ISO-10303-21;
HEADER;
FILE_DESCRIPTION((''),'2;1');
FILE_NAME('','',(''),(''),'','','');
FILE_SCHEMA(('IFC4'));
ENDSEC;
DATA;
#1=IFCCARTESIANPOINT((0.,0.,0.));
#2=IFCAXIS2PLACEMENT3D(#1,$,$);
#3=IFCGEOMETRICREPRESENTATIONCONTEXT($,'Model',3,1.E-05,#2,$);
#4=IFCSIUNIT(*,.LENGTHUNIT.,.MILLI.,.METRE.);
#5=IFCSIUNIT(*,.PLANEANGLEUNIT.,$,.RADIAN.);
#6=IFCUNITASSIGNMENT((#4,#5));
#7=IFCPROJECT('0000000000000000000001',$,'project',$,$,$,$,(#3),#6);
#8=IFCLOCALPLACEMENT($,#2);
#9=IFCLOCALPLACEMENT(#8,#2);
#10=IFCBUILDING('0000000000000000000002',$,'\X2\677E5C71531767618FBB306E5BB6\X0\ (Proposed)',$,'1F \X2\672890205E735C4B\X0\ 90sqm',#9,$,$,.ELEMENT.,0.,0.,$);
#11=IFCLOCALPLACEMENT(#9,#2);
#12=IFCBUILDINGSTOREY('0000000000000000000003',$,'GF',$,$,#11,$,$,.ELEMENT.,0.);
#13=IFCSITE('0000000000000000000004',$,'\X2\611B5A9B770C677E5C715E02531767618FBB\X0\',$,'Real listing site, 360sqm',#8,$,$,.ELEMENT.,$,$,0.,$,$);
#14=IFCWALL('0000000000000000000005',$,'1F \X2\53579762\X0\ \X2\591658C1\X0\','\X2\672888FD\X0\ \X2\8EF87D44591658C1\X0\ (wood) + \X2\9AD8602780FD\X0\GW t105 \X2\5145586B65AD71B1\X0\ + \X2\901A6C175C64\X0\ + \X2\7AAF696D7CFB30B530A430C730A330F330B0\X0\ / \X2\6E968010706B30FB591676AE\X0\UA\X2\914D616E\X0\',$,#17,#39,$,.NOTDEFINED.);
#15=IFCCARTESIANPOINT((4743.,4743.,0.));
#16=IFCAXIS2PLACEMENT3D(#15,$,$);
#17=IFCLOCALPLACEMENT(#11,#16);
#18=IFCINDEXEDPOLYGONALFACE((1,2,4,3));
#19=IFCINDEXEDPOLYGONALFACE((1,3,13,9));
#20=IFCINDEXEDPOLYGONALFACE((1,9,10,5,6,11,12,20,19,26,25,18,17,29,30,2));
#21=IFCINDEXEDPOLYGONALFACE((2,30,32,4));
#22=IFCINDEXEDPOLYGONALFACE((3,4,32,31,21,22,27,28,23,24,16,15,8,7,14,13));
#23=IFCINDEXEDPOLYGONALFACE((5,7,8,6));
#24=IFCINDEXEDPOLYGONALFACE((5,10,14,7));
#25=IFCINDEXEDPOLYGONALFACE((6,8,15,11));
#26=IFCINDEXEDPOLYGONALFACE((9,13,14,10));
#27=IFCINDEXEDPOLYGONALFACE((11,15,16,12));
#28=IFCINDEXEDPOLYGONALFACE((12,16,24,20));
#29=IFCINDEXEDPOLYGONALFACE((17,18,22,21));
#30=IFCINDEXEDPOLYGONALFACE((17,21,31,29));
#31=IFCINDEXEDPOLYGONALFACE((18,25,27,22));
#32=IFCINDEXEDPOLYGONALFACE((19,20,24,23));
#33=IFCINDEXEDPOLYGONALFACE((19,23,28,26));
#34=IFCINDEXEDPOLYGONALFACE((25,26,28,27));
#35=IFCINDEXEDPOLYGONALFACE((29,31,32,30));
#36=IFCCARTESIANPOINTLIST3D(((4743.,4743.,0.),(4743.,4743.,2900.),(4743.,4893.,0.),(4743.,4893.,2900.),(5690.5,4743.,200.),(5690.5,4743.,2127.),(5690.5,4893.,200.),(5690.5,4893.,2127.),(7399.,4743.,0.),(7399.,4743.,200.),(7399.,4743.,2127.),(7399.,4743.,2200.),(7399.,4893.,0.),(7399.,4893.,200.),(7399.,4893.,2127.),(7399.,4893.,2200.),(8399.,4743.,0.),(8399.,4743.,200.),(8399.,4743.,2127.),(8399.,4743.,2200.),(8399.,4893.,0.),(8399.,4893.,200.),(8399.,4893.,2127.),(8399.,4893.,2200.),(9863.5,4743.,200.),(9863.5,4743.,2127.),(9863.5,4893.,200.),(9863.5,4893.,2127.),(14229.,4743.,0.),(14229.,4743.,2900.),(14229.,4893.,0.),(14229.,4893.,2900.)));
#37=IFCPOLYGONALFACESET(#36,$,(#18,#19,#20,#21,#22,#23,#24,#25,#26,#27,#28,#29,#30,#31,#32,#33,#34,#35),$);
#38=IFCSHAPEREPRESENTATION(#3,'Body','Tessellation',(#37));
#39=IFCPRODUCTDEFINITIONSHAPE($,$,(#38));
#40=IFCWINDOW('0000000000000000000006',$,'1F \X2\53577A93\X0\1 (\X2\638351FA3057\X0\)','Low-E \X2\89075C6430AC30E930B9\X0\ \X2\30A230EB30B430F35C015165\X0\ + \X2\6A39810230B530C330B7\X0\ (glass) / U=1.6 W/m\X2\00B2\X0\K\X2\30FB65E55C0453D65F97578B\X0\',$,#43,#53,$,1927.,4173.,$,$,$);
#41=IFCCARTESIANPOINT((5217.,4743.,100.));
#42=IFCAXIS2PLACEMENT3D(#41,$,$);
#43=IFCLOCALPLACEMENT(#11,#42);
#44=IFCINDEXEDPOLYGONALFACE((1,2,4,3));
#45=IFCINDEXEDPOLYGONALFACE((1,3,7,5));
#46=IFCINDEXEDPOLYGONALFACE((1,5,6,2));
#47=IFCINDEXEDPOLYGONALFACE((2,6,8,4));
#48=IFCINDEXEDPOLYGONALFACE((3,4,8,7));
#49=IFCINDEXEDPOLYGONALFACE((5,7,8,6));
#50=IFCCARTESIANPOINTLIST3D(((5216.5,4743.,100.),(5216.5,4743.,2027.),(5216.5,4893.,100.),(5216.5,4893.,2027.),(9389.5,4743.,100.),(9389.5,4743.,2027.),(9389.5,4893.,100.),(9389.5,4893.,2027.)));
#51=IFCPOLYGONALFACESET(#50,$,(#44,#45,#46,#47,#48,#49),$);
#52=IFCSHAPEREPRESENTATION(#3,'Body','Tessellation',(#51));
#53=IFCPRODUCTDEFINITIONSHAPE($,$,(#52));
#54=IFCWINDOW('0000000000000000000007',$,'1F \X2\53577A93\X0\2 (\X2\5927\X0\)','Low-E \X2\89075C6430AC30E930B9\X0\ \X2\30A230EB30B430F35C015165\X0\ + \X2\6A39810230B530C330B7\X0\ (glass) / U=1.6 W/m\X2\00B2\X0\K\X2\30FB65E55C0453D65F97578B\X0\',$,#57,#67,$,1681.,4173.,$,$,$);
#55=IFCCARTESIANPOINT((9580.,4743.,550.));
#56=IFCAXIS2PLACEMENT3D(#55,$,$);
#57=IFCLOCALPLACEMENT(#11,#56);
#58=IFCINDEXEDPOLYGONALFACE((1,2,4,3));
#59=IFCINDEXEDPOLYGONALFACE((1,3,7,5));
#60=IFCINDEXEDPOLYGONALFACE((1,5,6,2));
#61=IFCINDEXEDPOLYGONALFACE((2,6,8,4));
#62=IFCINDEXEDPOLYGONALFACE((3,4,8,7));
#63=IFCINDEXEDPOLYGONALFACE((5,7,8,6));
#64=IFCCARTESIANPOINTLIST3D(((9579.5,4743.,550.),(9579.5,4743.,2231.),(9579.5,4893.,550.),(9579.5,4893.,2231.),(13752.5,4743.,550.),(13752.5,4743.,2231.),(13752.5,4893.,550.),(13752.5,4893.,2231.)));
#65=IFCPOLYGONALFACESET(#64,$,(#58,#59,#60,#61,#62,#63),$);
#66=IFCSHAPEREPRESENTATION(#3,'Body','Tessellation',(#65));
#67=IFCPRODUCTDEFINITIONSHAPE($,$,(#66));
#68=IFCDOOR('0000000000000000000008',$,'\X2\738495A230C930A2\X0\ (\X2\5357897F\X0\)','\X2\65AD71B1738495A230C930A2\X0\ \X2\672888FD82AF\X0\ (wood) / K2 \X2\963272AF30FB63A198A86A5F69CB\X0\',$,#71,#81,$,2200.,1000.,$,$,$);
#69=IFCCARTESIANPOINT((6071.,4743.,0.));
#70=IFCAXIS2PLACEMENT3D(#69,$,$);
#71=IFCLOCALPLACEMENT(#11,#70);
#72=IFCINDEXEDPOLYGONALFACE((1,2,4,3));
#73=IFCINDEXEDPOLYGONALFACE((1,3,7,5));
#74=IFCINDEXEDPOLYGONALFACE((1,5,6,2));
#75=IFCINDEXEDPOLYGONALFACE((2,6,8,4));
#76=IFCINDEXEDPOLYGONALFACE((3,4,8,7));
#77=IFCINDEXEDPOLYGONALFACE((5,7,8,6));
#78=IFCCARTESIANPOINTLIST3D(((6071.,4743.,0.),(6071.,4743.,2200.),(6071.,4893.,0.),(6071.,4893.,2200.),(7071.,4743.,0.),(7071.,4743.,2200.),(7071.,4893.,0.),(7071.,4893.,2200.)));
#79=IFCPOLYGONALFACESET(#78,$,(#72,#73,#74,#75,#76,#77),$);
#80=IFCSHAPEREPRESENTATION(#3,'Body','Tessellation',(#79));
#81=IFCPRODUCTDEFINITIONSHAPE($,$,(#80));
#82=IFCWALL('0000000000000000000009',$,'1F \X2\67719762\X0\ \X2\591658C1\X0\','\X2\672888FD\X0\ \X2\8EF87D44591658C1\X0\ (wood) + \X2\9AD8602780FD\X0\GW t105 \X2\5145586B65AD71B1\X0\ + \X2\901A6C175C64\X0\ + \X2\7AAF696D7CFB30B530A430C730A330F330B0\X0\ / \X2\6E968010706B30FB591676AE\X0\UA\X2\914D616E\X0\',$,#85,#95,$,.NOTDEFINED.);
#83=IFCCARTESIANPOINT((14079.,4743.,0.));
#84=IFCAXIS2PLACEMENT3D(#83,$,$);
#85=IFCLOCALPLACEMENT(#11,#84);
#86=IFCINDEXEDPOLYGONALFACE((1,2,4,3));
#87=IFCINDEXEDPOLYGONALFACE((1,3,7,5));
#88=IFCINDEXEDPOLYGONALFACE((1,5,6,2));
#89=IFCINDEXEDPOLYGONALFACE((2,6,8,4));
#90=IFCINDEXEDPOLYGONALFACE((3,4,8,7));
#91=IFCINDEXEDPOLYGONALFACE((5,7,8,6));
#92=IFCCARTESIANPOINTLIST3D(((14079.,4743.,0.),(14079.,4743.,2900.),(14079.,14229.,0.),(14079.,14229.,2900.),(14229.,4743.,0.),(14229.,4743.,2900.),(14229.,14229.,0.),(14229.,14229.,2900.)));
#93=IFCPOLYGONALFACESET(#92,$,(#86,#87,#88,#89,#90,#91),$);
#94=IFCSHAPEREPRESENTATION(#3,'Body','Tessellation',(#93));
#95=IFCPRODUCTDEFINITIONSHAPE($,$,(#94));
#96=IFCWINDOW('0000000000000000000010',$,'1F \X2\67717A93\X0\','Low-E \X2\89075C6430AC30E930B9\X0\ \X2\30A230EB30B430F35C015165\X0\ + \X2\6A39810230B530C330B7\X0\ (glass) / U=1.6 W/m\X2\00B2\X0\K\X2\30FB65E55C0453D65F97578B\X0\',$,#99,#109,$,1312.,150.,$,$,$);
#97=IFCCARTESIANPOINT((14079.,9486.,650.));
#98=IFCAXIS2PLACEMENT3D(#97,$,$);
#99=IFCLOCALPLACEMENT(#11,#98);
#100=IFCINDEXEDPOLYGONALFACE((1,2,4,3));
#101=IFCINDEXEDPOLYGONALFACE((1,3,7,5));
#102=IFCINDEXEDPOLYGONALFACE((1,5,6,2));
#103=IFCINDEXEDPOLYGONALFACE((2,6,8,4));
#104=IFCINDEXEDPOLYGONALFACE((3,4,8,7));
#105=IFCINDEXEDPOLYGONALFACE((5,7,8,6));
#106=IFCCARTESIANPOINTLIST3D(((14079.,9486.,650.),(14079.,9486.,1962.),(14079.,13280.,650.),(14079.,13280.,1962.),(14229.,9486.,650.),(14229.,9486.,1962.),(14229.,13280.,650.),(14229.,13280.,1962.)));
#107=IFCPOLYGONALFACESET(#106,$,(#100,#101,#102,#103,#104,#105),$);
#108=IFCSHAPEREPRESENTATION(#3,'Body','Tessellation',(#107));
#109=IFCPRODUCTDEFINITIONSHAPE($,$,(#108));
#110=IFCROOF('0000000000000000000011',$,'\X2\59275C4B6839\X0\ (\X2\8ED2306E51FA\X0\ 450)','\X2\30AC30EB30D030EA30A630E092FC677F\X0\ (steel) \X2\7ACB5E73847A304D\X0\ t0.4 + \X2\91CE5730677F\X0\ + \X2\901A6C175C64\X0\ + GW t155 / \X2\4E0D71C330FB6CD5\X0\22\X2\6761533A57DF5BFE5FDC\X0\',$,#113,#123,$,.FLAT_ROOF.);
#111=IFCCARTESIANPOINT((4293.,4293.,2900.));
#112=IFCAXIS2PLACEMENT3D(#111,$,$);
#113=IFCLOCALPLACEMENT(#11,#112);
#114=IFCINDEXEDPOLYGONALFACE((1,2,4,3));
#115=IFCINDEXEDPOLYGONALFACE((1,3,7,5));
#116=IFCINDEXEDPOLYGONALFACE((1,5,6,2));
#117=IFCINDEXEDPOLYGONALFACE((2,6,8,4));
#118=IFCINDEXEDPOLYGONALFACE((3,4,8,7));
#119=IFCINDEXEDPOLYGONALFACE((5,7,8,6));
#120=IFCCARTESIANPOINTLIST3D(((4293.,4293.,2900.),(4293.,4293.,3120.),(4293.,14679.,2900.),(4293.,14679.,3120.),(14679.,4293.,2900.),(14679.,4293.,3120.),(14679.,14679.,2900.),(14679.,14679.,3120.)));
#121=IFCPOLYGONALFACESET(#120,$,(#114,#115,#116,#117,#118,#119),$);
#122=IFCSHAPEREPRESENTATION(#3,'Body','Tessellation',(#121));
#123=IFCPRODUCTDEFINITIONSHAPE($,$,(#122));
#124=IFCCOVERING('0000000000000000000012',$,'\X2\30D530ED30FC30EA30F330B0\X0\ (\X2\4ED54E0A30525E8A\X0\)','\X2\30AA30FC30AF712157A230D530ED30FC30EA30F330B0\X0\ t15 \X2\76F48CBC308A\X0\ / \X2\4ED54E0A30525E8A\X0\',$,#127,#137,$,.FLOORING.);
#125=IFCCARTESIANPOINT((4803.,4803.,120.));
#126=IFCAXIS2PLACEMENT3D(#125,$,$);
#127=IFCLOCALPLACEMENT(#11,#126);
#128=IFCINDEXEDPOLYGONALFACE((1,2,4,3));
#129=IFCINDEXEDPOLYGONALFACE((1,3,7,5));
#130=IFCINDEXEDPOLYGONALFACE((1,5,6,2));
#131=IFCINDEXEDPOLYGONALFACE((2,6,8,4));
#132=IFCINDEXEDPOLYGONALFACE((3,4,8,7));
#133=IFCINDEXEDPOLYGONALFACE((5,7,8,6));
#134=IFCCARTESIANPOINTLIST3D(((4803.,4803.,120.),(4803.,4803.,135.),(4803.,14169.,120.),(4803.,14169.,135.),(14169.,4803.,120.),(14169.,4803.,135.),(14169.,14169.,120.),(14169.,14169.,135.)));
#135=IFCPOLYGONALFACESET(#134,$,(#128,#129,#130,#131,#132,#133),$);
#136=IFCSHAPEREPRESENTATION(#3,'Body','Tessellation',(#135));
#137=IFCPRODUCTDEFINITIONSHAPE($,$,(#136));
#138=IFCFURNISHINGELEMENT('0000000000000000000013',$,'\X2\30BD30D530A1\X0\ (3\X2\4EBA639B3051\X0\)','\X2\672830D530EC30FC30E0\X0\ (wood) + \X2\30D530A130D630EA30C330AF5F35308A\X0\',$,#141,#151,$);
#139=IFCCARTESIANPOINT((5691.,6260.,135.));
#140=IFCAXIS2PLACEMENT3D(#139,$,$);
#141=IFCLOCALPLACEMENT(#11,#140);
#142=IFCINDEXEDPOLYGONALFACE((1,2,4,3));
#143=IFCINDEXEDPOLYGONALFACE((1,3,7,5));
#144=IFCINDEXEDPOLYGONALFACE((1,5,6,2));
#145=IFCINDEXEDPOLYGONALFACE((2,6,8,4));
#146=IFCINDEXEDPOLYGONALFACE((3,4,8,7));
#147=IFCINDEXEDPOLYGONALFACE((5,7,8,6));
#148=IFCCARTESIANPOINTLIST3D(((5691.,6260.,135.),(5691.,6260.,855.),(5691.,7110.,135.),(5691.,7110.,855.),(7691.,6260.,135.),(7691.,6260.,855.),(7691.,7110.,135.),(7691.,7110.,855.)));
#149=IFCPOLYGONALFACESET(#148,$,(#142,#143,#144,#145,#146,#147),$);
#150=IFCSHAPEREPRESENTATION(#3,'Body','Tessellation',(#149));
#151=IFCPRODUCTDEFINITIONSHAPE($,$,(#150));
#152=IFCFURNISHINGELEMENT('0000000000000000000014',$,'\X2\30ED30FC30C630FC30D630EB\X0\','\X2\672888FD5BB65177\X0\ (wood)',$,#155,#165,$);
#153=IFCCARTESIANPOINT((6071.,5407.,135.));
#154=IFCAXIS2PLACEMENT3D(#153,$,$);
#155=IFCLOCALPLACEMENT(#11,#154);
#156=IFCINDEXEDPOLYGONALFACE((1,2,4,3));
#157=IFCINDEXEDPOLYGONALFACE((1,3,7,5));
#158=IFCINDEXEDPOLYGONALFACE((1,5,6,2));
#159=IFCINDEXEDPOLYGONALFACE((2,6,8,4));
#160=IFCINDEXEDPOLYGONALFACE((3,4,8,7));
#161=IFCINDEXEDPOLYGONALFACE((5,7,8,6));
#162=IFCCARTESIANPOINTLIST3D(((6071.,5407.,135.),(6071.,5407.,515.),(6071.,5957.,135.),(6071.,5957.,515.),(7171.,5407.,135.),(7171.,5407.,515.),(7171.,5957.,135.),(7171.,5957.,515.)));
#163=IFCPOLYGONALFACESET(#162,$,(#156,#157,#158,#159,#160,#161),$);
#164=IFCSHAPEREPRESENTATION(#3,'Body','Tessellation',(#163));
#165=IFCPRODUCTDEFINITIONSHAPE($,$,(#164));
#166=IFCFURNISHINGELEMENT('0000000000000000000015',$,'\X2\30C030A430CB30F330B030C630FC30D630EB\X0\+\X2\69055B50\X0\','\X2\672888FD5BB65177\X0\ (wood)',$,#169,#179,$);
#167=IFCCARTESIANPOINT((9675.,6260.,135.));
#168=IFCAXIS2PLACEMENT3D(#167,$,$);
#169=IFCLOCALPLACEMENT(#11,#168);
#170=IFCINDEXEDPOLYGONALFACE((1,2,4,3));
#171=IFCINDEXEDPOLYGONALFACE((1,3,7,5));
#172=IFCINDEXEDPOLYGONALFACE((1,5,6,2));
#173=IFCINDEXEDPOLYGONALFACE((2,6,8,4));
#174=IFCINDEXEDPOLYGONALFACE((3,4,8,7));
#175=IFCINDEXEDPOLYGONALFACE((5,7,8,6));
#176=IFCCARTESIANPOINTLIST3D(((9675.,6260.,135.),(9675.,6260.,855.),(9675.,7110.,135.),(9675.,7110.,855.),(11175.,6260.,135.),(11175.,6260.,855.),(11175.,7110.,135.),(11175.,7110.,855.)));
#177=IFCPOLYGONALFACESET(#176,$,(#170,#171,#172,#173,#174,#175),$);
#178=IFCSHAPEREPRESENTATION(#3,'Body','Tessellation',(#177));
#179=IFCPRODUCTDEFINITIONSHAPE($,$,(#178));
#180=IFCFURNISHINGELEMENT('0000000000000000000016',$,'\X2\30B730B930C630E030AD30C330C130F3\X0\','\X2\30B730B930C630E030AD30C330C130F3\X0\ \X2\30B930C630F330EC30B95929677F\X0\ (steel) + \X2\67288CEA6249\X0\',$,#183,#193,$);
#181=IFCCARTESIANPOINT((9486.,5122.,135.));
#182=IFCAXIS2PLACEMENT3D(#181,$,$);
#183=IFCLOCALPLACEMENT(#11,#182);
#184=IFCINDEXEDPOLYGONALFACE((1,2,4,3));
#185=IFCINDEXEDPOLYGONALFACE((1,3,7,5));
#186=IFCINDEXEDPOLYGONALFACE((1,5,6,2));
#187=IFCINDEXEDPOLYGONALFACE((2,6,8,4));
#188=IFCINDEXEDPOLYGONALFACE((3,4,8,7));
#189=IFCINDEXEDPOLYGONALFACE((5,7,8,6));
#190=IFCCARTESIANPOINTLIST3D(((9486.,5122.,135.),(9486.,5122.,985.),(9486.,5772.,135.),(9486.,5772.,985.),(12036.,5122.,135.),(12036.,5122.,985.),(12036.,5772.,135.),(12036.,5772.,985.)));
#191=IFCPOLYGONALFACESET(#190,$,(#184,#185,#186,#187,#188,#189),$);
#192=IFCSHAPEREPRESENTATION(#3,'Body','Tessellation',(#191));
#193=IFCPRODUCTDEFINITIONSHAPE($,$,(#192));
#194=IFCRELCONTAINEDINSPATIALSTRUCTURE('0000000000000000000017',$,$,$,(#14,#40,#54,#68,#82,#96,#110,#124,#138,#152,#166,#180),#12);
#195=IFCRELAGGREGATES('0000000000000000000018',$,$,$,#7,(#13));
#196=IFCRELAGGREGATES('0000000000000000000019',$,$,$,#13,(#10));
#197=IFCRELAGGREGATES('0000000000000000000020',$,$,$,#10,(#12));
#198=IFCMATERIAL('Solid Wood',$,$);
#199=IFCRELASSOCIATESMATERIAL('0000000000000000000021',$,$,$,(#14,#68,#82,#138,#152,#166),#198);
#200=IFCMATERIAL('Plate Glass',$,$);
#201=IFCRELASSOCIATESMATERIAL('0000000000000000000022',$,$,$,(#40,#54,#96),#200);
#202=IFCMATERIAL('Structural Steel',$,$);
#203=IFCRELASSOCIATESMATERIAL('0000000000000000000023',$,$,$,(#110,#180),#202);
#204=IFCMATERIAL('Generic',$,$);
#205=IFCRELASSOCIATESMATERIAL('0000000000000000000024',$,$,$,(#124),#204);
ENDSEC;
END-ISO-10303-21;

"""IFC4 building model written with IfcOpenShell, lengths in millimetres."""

from ifc_helpers import new_model, si_unit, frame, frame_2d, origin, place, context, project, spatial, rectangle, extrude, material, element, fill, save


model = new_model("IFC4")

# Units and contexts
model_context = context("Model", 3, precision=1e-05, world=origin())
ifc_project = project(units=[si_unit("LENGTHUNIT", "METRE", prefix="MILLI"), si_unit("PLANEANGLEUNIT", "RADIAN")], contexts=[model_context])

# Site, building, storey
site_placement = place(None, origin())
site = spatial("IfcSite", under=ifc_project, at=site_placement, Name="愛媛県松山市北条辻", ObjectType="Real listing site, 360sqm", CompositionType="ELEMENT", RefElevation=0.0)
building_placement = place(site_placement, origin())
building = spatial("IfcBuilding", under=site, at=building_placement, Name="松山北条辻の家 (Proposed)", ObjectType="1F 木造平屋 90sqm", CompositionType="ELEMENT", ElevationOfRefHeight=0.0, ElevationOfTerrain=0.0)
storey_placement = place(building_placement, origin())
storey = spatial("IfcBuildingStorey", under=building, at=storey_placement, Name="GF", CompositionType="ELEMENT", Elevation=0.0)

# Shared definitions
ifc_material_1 = material(Name="Solid Wood")

# Wall, openings, windows, door
wall_1_placement = place(storey_placement, frame((4743.0, 4743.0, 0.0)))
wall_1 = element("IfcWall", 1, at=wall_1_placement, inside=storey, material=ifc_material_1, Name="1F 南面 外壁", Description="木製 軸組外壁 (wood) + 高性能GW t105 充填断熱 + 通気層 + 窯業系サイディング / 準耐火・外皮UA配慮", PredefinedType="NOTDEFINED", context=model_context, shape_type="SweptSolid", body=[
    extrude(rectangle(XDim=9486.0, YDim=150.0, at=frame_2d((4743.0, 75.0))), frame((4743.0, 4743.0, 0.0)), (0.0, 0.0, 1.0), 2900.0),
])
opening_1_placement = place(storey_placement, frame((5217.0, 4743.0, 100.0)))
opening_1 = element("IfcOpeningElement", 2, at=opening_1_placement, cuts=wall_1, PredefinedType="NOTDEFINED", context=model_context, shape_type="SweptSolid", body=[
    extrude(rectangle(XDim=4173.0, YDim=150.0, at=frame_2d((2086.0, 75.0))), frame((5217.0, 4743.0, 100.0)), (0.0, 0.0, 1.0), 1927.0),
])
opening_2_placement = place(storey_placement, frame((9580.0, 4743.0, 550.0)))
opening_2 = element("IfcOpeningElement", 3, at=opening_2_placement, cuts=wall_1, PredefinedType="NOTDEFINED", context=model_context, shape_type="SweptSolid", body=[
    extrude(rectangle(XDim=4173.0, YDim=150.0, at=frame_2d((2086.0, 75.0))), frame((9580.0, 4743.0, 550.0)), (0.0, 0.0, 1.0), 1681.0),
])
opening_3_placement = place(storey_placement, frame((6071.0, 4743.0, 0.0)))
opening_3 = element("IfcOpeningElement", 4, at=opening_3_placement, cuts=wall_1, PredefinedType="NOTDEFINED", context=model_context, shape_type="SweptSolid", body=[
    extrude(rectangle(XDim=1000.0, YDim=150.0, at=frame_2d((500.0, 75.0))), frame((6071.0, 4743.0, 0.0)), (0.0, 0.0, 1.0), 2200.0),
])
ifc_material_2 = material(Name="Plate Glass")
window_1_placement = place(storey_placement, frame((5217.0, 4743.0, 100.0)))
window_1 = element("IfcWindow", 5, at=window_1_placement, inside=storey, material=ifc_material_2, Name="1F 南窓1 (掃出し)", Description="Low-E 複層ガラス アルゴン封入 + 樹脂サッシ (glass) / U=1.6 W/m²K・日射取得型", OverallHeight=1927.0, OverallWidth=4173.0, context=model_context, shape_type="SweptSolid", body=[
    extrude(rectangle(XDim=4173.0, YDim=150.0, at=frame_2d((2086.0, 75.0))), frame((5217.0, 4743.0, 100.0)), (0.0, 0.0, 1.0), 1927.0),
])
fill(opening_1, window_1)
window_2_placement = place(storey_placement, frame((9580.0, 4743.0, 550.0)))
window_2 = element("IfcWindow", 6, at=window_2_placement, inside=storey, material=ifc_material_2, Name="1F 南窓2 (大)", Description="Low-E 複層ガラス アルゴン封入 + 樹脂サッシ (glass) / U=1.6 W/m²K・日射取得型", OverallHeight=1681.0, OverallWidth=4173.0, context=model_context, shape_type="SweptSolid", body=[
    extrude(rectangle(XDim=4173.0, YDim=150.0, at=frame_2d((2086.0, 75.0))), frame((9580.0, 4743.0, 550.0)), (0.0, 0.0, 1.0), 1681.0),
])
fill(opening_2, window_2)
door_placement = place(storey_placement, frame((6071.0, 4743.0, 0.0)))
door = element("IfcDoor", 7, at=door_placement, inside=storey, material=ifc_material_1, Name="玄関ドア (南西)", Description="断熱玄関ドア 木製芯 (wood) / K2 防犯・採風機構", OverallHeight=2200.0, OverallWidth=1000.0, context=model_context, shape_type="SweptSolid", body=[
    extrude(rectangle(XDim=1000.0, YDim=150.0, at=frame_2d((500.0, 75.0))), frame((6071.0, 4743.0, 0.0)), (0.0, 0.0, 1.0), 2200.0),
])
fill(opening_3, door)

# Wall, opening, window
wall_2_placement = place(storey_placement, frame((14079.0, 4743.0, 0.0)))
wall_2 = element("IfcWall", 8, at=wall_2_placement, inside=storey, material=ifc_material_1, Name="1F 東面 外壁", Description="木製 軸組外壁 (wood) + 高性能GW t105 充填断熱 + 通気層 + 窯業系サイディング / 準耐火・外皮UA配慮", PredefinedType="NOTDEFINED", context=model_context, shape_type="SweptSolid", body=[
    extrude(rectangle(XDim=150.0, YDim=9486.0, at=frame_2d((75.0, 4743.0))), frame((14079.0, 4743.0, 0.0)), (0.0, 0.0, 1.0), 2900.0),
])
opening_4_placement = place(storey_placement, frame((14079.0, 9486.0, 650.0)))
opening_4 = element("IfcOpeningElement", 9, at=opening_4_placement, cuts=wall_2, PredefinedType="NOTDEFINED", context=model_context, shape_type="SweptSolid", body=[
    extrude(rectangle(XDim=150.0, YDim=3794.0, at=frame_2d((75.0, 1897.0))), frame((14079.0, 9486.0, 650.0)), (0.0, 0.0, 1.0), 1312.0),
])
window_3_placement = place(storey_placement, frame((14079.0, 9486.0, 650.0)))
window_3 = element("IfcWindow", 10, at=window_3_placement, inside=storey, material=ifc_material_2, Name="1F 東窓", Description="Low-E 複層ガラス アルゴン封入 + 樹脂サッシ (glass) / U=1.6 W/m²K・日射取得型", OverallHeight=1312.0, OverallWidth=150.0, context=model_context, shape_type="SweptSolid", body=[
    extrude(rectangle(XDim=150.0, YDim=3794.0, at=frame_2d((75.0, 1897.0))), frame((14079.0, 9486.0, 650.0)), (0.0, 0.0, 1.0), 1312.0),
])
fill(opening_4, window_3)

# Roof
ifc_material_3 = material(Name="Structural Steel")
roof_placement = place(storey_placement, frame((4293.0, 4293.0, 2900.0)))
element("IfcRoof", 11, at=roof_placement, inside=storey, material=ifc_material_3, Name="大屋根 (軒の出 450)", Description="ガルバリウム鋼板 (steel) 立平葺き t0.4 + 野地板 + 通気層 + GW t155 / 不燃・法22条区域対応", PredefinedType="FLAT_ROOF", context=model_context, shape_type="SweptSolid", body=[
    extrude(rectangle(XDim=10386.0, YDim=10386.0, at=frame_2d((5193.0, 5193.0))), frame((4293.0, 4293.0, 2900.0)), (0.0, 0.0, 1.0), 220.0),
])

# Covering
ifc_material_4 = material(Name="Generic")
covering_placement = place(storey_placement, frame((4803.0, 4803.0, 120.0)))
element("IfcCovering", 12, at=covering_placement, inside=storey, material=ifc_material_4, Name="フローリング (仕上げ床)", Description="オーク無垢フローリング t15 直貼り / 仕上げ床", PredefinedType="FLOORING", context=model_context, shape_type="SweptSolid", body=[
    extrude(rectangle(XDim=9366.0, YDim=9366.0, at=frame_2d((4683.0, 4683.0))), frame((4803.0, 4803.0, 120.0)), (0.0, 0.0, 1.0), 15.0),
])

# Furnishing elements
furnishing_1_placement = place(storey_placement, frame((5691.0, 6260.0, 135.0)))
element("IfcFurnishingElement", 13, at=furnishing_1_placement, inside=storey, material=ifc_material_1, Name="ソファ (3人掛け)", Description="木フレーム (wood) + ファブリック張り", context=model_context, shape_type="SweptSolid", body=[
    extrude(rectangle(XDim=2000.0, YDim=850.0, at=frame_2d((1000.0, 425.0))), frame((5691.0, 6260.0, 135.0)), (0.0, 0.0, 1.0), 720.0),
])
furnishing_2_placement = place(storey_placement, frame((6071.0, 5407.0, 135.0)))
element("IfcFurnishingElement", 14, at=furnishing_2_placement, inside=storey, material=ifc_material_1, Name="ローテーブル", Description="木製家具 (wood)", context=model_context, shape_type="SweptSolid", body=[
    extrude(rectangle(XDim=1100.0, YDim=550.0, at=frame_2d((550.0, 275.0))), frame((6071.0, 5407.0, 135.0)), (0.0, 0.0, 1.0), 380.0),
])
furnishing_3_placement = place(storey_placement, frame((9675.0, 6260.0, 135.0)))
element("IfcFurnishingElement", 15, at=furnishing_3_placement, inside=storey, material=ifc_material_1, Name="ダイニングテーブル+椅子", Description="木製家具 (wood)", context=model_context, shape_type="SweptSolid", body=[
    extrude(rectangle(XDim=1500.0, YDim=850.0, at=frame_2d((750.0, 425.0))), frame((9675.0, 6260.0, 135.0)), (0.0, 0.0, 1.0), 720.0),
])
furnishing_4_placement = place(storey_placement, frame((9486.0, 5122.0, 135.0)))
element("IfcFurnishingElement", 16, at=furnishing_4_placement, inside=storey, material=ifc_material_3, Name="システムキッチン", Description="システムキッチン ステンレス天板 (steel) + 木質扉", context=model_context, shape_type="SweptSolid", body=[
    extrude(rectangle(XDim=2550.0, YDim=650.0, at=frame_2d((1275.0, 325.0))), frame((9486.0, 5122.0, 135.0)), (0.0, 0.0, 1.0), 850.0),
])

save(model, "model.ifc")
